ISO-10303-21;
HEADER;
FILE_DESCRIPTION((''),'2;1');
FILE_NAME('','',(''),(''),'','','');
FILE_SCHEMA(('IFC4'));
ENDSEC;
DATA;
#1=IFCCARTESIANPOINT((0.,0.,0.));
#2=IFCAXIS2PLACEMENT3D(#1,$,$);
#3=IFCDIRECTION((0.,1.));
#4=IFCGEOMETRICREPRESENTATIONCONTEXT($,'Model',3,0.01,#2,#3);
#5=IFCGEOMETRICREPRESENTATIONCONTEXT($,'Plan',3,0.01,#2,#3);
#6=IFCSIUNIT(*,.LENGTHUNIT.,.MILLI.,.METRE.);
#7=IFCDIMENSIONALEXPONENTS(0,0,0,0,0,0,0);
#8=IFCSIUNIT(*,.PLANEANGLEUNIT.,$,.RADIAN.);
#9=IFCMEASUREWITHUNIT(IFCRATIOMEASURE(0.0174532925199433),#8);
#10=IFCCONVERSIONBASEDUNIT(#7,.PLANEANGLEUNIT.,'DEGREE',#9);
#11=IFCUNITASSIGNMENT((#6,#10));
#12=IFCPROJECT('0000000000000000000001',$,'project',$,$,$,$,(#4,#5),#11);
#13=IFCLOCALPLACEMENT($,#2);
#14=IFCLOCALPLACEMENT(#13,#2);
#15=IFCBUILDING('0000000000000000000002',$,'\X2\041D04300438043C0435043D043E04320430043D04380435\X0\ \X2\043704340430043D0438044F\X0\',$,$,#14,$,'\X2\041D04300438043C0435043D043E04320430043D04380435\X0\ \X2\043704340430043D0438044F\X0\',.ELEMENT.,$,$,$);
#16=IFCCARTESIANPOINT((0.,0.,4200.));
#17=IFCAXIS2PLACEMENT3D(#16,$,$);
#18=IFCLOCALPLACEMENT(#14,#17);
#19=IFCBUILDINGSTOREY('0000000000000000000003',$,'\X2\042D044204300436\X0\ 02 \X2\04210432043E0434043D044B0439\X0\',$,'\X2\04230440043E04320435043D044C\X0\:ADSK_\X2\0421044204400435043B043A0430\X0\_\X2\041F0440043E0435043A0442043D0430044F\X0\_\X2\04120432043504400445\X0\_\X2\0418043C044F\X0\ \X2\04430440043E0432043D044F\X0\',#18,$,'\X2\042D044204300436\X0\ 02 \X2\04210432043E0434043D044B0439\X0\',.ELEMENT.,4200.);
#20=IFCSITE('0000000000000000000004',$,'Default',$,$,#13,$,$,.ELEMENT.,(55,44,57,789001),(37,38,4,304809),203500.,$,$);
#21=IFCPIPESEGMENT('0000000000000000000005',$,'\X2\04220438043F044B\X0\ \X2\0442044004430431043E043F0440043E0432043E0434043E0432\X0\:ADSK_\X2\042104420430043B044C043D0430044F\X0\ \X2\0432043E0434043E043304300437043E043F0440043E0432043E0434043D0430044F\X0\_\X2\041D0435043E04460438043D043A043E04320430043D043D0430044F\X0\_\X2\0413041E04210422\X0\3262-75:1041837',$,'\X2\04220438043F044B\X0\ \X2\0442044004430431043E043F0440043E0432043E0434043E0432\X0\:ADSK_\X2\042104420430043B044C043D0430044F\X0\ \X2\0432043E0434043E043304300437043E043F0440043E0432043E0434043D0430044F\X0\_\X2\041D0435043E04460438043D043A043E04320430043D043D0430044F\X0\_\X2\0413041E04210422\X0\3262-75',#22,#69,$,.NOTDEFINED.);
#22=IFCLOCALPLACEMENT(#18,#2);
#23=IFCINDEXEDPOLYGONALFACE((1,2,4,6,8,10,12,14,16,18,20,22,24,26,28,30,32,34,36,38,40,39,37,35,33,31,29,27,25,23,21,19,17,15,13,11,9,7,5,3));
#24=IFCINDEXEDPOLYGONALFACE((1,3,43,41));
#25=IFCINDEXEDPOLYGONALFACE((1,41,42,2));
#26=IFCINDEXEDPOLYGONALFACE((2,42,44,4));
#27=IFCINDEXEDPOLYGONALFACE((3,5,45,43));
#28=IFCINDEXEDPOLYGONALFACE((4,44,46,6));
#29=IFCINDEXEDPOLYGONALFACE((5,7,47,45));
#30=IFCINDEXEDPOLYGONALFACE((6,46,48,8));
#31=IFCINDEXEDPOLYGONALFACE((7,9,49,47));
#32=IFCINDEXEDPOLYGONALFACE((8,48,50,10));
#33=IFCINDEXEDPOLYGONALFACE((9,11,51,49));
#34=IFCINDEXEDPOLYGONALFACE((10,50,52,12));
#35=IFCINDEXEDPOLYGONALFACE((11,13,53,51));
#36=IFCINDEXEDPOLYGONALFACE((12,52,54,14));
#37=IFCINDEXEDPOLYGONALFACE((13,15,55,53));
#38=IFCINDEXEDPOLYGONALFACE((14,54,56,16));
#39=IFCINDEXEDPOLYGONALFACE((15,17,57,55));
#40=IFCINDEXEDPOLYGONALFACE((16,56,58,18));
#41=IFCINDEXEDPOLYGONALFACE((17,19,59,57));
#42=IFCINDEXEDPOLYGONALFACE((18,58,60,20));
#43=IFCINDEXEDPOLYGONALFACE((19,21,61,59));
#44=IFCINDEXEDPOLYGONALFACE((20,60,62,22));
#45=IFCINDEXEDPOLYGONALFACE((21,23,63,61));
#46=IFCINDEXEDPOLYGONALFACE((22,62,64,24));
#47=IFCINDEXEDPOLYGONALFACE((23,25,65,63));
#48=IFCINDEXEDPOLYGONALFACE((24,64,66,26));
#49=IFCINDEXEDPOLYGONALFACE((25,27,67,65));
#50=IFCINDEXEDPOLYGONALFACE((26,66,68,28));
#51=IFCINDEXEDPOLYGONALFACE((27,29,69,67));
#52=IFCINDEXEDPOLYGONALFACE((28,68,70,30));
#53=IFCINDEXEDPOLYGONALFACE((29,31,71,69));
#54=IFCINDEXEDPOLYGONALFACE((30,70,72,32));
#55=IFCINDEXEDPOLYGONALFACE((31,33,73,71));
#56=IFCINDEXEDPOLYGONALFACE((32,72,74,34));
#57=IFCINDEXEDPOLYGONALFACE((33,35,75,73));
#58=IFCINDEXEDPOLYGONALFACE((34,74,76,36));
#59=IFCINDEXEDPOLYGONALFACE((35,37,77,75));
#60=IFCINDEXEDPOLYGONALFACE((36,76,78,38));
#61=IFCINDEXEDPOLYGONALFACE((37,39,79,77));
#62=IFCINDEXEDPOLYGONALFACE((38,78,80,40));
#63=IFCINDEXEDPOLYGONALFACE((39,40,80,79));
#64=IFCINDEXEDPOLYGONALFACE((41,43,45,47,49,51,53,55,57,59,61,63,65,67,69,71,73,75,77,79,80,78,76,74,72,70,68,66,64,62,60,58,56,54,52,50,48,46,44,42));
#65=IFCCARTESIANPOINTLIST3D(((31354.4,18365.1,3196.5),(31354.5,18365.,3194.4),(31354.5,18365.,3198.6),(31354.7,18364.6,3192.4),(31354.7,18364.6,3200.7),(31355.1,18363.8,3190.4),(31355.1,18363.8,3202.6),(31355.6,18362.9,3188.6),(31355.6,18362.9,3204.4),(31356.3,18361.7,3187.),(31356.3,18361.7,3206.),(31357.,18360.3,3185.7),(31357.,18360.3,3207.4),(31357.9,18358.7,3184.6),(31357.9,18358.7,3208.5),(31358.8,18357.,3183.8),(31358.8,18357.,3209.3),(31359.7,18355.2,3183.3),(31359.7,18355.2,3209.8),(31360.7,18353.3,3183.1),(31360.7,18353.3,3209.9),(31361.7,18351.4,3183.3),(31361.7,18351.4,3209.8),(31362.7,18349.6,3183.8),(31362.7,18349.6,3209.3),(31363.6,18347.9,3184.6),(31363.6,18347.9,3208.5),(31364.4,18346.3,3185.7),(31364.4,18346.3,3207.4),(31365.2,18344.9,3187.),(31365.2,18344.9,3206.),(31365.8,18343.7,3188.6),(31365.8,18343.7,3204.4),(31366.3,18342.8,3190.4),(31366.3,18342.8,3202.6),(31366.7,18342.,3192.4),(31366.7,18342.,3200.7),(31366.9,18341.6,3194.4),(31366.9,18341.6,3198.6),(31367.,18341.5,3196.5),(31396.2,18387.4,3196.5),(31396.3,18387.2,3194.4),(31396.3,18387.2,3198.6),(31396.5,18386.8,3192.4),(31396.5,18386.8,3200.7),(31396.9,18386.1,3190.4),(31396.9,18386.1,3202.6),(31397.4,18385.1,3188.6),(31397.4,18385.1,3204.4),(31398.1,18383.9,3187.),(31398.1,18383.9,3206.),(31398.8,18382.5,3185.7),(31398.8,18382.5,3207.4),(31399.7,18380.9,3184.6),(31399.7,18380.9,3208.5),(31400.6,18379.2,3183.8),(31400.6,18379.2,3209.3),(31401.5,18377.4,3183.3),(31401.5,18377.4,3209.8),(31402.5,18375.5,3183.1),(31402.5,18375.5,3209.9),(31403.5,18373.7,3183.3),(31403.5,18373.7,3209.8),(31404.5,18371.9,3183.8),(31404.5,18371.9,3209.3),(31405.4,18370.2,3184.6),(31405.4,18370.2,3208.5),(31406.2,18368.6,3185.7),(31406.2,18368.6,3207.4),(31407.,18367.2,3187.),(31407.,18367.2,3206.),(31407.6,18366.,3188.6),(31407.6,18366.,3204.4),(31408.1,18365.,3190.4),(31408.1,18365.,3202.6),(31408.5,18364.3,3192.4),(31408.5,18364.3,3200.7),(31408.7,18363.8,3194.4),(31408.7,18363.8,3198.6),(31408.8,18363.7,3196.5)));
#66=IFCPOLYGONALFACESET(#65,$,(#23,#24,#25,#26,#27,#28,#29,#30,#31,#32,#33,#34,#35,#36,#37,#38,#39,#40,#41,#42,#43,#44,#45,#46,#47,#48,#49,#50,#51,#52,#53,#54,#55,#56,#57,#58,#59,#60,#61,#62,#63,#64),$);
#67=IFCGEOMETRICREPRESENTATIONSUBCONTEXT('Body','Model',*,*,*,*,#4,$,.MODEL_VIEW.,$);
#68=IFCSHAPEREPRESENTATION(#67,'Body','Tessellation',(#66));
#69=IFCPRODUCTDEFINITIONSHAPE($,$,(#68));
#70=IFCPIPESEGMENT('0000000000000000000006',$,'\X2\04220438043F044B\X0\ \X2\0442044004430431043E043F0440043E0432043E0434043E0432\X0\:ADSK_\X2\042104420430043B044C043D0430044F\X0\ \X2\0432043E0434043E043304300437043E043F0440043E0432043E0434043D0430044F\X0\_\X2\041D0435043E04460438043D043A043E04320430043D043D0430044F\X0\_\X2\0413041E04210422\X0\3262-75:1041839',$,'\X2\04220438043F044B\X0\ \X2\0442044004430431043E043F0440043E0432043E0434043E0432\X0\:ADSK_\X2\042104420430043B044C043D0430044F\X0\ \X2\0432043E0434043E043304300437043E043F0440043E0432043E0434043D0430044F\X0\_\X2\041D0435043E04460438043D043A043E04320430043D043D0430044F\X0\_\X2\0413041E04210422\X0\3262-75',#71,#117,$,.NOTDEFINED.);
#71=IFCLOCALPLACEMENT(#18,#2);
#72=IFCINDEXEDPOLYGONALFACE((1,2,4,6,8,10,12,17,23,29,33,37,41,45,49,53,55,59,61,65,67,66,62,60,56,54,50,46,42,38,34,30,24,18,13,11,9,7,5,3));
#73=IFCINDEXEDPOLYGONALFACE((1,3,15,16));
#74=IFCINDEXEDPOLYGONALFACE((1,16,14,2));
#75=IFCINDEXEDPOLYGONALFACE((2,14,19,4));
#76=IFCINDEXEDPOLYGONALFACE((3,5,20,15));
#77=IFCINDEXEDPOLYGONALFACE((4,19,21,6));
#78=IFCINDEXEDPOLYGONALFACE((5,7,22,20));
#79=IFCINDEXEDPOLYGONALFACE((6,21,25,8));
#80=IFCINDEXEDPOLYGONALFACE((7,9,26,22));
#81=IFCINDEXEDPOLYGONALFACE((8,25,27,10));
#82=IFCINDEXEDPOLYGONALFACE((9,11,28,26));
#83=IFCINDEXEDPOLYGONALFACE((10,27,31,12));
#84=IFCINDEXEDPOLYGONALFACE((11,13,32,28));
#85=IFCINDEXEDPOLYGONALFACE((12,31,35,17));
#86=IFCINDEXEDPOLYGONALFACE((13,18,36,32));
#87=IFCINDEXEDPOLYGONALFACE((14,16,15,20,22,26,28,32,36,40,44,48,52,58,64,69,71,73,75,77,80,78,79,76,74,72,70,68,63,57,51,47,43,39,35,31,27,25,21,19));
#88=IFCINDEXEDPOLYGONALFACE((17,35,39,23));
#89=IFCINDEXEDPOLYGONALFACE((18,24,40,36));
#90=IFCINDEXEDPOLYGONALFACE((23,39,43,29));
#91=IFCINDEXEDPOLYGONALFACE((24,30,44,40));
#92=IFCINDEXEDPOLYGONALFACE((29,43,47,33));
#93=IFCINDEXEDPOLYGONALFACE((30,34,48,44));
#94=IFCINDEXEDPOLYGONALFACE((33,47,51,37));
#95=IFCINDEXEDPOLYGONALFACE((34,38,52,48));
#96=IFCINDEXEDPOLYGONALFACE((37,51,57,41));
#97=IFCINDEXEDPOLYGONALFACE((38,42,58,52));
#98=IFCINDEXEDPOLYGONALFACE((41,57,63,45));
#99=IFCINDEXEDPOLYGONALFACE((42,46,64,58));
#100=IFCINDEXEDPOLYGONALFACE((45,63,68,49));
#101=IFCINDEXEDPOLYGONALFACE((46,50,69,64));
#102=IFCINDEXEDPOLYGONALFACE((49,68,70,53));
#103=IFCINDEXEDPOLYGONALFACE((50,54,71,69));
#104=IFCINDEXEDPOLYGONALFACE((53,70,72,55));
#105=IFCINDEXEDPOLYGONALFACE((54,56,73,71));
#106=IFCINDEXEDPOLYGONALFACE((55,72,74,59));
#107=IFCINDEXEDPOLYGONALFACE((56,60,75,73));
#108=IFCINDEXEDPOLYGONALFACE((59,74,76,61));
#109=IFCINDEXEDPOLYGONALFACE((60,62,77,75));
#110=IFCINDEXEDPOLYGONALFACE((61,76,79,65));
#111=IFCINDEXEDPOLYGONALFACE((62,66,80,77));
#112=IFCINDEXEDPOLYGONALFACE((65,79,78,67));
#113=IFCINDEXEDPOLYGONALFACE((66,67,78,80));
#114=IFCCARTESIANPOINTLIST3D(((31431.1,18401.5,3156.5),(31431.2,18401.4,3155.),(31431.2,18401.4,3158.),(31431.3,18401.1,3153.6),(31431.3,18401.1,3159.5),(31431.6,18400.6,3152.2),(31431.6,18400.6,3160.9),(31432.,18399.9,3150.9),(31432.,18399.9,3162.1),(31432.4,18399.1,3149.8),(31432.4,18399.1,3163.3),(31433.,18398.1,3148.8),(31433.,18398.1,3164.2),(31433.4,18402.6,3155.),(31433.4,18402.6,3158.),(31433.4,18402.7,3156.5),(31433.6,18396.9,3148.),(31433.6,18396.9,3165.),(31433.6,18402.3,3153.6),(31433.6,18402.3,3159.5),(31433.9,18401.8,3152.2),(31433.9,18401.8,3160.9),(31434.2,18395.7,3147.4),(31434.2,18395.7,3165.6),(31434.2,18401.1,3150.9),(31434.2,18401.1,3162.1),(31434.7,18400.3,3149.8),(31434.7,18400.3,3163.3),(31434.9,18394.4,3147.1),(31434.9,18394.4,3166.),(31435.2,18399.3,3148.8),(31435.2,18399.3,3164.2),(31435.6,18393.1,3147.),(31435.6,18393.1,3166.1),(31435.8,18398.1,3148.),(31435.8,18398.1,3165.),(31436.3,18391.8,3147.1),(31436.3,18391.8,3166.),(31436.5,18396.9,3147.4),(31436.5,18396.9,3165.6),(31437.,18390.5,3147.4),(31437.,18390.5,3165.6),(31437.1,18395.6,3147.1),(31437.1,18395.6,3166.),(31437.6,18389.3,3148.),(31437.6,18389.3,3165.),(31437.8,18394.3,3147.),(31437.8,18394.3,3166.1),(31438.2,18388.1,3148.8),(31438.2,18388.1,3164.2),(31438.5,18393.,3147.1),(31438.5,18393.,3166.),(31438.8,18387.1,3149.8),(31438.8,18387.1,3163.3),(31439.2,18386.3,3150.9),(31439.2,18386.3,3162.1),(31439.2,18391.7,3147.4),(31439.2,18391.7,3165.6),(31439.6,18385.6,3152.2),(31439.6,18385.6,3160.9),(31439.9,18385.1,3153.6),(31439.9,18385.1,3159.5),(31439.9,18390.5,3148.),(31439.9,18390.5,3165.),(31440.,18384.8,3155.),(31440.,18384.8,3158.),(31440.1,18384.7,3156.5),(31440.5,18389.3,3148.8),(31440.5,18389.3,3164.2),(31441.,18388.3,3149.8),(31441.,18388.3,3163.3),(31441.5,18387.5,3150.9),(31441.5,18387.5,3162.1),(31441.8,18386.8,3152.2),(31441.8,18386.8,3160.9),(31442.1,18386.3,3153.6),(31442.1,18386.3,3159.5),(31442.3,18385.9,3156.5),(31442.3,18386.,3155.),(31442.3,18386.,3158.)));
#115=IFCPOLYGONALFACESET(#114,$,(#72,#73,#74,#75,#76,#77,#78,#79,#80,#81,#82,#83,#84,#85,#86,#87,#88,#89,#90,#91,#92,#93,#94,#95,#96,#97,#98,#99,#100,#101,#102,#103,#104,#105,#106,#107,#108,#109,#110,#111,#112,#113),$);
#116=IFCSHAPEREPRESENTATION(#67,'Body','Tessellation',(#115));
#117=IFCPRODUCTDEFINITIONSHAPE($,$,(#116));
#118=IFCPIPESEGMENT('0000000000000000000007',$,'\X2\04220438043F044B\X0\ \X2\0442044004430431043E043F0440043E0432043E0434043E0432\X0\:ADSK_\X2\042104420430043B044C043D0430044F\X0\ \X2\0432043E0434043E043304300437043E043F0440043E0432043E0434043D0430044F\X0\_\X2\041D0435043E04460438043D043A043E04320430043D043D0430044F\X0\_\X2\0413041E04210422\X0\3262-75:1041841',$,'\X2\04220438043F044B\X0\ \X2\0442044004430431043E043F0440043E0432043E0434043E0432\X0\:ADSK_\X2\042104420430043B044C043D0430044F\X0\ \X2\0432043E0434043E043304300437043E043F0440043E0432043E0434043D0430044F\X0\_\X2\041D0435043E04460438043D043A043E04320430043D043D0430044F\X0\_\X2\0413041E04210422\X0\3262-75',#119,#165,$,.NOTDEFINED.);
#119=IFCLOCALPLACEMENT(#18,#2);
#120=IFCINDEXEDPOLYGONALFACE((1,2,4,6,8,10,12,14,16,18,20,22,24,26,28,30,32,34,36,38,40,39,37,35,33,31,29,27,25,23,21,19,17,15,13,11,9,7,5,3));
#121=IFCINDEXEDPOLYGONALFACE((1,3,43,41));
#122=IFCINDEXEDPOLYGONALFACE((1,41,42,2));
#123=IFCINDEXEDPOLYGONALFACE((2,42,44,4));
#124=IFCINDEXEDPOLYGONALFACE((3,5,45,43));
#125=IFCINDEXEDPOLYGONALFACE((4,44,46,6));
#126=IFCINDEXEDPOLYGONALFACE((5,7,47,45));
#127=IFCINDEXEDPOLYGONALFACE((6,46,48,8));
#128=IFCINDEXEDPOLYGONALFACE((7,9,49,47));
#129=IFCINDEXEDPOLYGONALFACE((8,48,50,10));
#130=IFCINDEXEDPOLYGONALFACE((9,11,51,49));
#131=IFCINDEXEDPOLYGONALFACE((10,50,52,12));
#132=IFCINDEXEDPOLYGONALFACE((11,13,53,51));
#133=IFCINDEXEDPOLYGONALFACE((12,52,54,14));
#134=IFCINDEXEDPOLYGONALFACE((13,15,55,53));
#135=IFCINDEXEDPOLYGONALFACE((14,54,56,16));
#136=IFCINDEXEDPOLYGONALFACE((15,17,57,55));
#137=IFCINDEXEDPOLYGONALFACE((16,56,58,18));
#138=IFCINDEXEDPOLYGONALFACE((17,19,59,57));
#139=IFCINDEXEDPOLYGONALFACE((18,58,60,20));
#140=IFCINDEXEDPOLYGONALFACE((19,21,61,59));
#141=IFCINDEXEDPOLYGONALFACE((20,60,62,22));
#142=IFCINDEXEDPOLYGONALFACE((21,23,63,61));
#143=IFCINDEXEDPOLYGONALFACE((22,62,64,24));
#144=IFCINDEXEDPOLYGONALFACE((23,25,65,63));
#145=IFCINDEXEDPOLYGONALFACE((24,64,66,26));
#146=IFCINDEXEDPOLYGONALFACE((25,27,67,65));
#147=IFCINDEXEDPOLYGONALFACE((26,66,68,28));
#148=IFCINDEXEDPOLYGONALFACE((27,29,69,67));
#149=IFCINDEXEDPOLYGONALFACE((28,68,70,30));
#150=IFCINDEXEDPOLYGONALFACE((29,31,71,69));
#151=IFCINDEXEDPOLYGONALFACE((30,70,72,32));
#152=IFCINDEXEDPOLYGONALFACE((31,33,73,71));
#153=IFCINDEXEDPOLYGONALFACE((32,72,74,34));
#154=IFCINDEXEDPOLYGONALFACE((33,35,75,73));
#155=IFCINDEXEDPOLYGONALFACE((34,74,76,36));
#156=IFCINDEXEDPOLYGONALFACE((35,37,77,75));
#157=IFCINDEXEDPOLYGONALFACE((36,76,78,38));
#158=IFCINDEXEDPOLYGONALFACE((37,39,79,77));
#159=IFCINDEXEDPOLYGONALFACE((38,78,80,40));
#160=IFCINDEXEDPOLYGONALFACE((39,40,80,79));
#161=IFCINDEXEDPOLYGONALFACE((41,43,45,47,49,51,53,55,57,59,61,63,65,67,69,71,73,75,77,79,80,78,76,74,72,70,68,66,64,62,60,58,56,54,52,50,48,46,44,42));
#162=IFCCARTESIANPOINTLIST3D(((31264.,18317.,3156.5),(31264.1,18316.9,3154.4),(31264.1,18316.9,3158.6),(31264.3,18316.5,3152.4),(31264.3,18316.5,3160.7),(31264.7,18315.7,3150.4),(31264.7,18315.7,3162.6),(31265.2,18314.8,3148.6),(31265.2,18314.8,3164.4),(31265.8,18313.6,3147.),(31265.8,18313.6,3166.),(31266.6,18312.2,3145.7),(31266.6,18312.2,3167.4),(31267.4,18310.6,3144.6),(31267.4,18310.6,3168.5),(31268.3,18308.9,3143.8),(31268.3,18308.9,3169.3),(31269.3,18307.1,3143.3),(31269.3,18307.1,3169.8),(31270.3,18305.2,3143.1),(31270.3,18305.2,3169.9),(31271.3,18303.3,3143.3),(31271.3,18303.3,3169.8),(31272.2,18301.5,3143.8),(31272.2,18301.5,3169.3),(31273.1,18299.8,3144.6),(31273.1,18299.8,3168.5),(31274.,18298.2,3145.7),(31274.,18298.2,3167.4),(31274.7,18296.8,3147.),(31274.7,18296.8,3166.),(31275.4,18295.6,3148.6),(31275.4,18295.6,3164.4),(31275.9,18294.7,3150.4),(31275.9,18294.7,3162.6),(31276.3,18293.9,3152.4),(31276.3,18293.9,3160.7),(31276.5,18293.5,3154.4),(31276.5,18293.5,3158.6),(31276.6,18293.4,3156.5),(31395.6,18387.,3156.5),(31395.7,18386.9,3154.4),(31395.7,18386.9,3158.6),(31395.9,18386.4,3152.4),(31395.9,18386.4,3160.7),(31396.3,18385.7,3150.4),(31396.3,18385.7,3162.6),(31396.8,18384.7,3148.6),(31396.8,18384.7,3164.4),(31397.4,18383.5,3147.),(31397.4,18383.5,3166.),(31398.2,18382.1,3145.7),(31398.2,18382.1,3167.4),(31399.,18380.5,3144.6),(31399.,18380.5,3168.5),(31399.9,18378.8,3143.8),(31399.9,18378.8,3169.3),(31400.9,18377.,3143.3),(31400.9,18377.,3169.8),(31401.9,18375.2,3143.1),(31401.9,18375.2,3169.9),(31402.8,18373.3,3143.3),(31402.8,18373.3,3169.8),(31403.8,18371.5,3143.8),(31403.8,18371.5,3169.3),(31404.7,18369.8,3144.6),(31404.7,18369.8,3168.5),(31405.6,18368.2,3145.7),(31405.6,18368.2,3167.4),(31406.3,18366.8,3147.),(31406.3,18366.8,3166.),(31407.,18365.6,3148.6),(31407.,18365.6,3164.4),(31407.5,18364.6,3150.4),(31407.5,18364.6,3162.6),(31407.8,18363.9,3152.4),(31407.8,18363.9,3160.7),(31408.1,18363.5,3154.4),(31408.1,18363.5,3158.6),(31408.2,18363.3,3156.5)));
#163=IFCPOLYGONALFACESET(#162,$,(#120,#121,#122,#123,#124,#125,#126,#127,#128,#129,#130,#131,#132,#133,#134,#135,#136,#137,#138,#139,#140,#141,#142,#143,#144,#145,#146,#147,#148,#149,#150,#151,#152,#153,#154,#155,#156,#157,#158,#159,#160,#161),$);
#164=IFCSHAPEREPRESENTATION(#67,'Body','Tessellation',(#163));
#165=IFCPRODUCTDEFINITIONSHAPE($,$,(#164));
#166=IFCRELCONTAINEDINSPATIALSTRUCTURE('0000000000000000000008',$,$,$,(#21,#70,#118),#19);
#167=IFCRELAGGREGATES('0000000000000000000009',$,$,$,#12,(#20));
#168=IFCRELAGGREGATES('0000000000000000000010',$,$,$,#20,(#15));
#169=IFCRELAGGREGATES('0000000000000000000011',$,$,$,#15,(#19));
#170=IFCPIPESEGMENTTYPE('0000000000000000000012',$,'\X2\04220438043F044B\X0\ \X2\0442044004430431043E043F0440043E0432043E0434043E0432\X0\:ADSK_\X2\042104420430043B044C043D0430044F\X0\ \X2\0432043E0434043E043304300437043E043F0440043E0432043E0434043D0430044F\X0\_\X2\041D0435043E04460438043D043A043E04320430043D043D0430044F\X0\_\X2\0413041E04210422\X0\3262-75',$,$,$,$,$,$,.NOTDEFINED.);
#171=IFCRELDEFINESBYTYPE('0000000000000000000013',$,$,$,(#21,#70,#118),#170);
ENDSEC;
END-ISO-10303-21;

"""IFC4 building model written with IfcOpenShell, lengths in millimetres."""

from ifc_helpers import new_model, entity, si_unit, converted_unit, direction, frame, origin, place, context, subcontext, project, spatial, indexed_curve, outline, extrude, type_object, element, save


model = new_model("IFC4")

# Units and contexts
model_context = context("Model", 3, precision=0.01, world=origin(), true_north=direction((0.0, 1.0)))
plan_context = context("Plan", 3, precision=0.01, world=origin(), true_north=direction((0.0, 1.0)))
body_context = subcontext(model_context, "Body", "Model", "MODEL_VIEW")
ifc_project = project(units=[si_unit("LENGTHUNIT", "METRE", prefix="MILLI"), converted_unit("PLANEANGLEUNIT", "DEGREE", entity("IfcRatioMeasure", 0.0174532925199433), si_unit("PLANEANGLEUNIT", "RADIAN"), dimensions=[0, 0, 0, 0, 0, 0, 0])], contexts=[model_context, plan_context])

# Site, building, storey
site_placement = place(None, origin())
site = spatial("IfcSite", under=ifc_project, at=site_placement, Name="Default", CompositionType="ELEMENT", RefLatitude=(55, 44, 57, 789001), RefLongitude=(37, 38, 4, 304809), RefElevation=203500.0)
building_placement = place(site_placement, origin())
building = spatial("IfcBuilding", under=site, at=building_placement, Name="Наименование здания", LongName="Наименование здания", CompositionType="ELEMENT")
storey_placement = place(building_placement, frame((0.0, 0.0, 4200.0)))
storey = spatial("IfcBuildingStorey", under=building, at=storey_placement, Name="Этаж 02 Сводный", ObjectType="Уровень:ADSK_Стрелка_Проектная_Вверх_Имя уровня", LongName="Этаж 02 Сводный", CompositionType="ELEMENT", Elevation=4200.0)

# Pipe segments
pipe_segment_type = type_object("IfcPipeSegmentType", Name="Типы трубопроводов:ADSK_Стальная водогазопроводная_Неоцинкованная_ГОСТ3262-75", PredefinedType="NOTDEFINED")
placement = place(storey_placement, origin())
element("IfcPipeSegment", 1, at=placement, inside=storey, type_object=pipe_segment_type, Name="Типы трубопроводов:ADSK_Стальная водогазопроводная_Неоцинкованная_ГОСТ3262-75:1041837", ObjectType="Типы трубопроводов:ADSK_Стальная водогазопроводная_Неоцинкованная_ГОСТ3262-75", PredefinedType="NOTDEFINED", context=body_context, shape_type="SweptSolid", body=[
    extrude(outline(indexed_curve([(13.4, 0.0), (13.2, 2.1), (12.7, 4.1), (11.9, 6.1), (10.8, 7.9), (9.5, 9.5), (7.9, 10.8), (6.1, 11.9), (4.1, 12.7), (2.1, 13.2), (0.0, 13.4), (-2.1, 13.2), (-4.1, 12.7), (-6.1, 11.9), (-7.9, 10.8), (-9.5, 9.5), (-10.8, 7.9), (-11.9, 6.1), (-12.7, 4.1), (-13.2, 2.1), (-13.4, 0.0), (-13.2, -2.1), (-12.7, -4.1), (-11.9, -6.1), (-10.8, -7.9), (-9.5, -9.5), (-7.9, -10.8), (-6.1, -11.9), (-4.1, -12.7), (-2.1, -13.2), (0.0, -13.4), (2.1, -13.2), (4.1, -12.7), (6.1, -11.9), (7.9, -10.8), (9.5, -9.5), (10.8, -7.9), (11.9, -6.1), (12.7, -4.1), (13.2, -2.1), (13.4, 0.0)], self_intersect=False)), frame((31360.7, 18353.3, 3196.5), z_axis=(0.882948, 0.469472, 0.0), x_axis=(-0.469472, 0.882948, 0.0)), (0.0, 0.0, 1.0), 47.3),
])
element("IfcPipeSegment", 2, at=placement, inside=storey, type_object=pipe_segment_type, Name="Типы трубопроводов:ADSK_Стальная водогазопроводная_Неоцинкованная_ГОСТ3262-75:1041839", ObjectType="Типы трубопроводов:ADSK_Стальная водогазопроводная_Неоцинкованная_ГОСТ3262-75", PredefinedType="NOTDEFINED", context=body_context, shape_type="SweptSolid", body=[
    extrude(outline(indexed_curve([(9.6, 0.0), (9.4, 1.5), (9.1, 3.0), (8.5, 4.3), (7.7, 5.6), (6.8, 6.8), (5.6, 7.7), (4.3, 8.5), (3.0, 9.1), (1.5, 9.4), (0.0, 9.6), (-1.5, 9.4), (-3.0, 9.1), (-4.3, 8.5), (-5.6, 7.7), (-6.8, 6.8), (-7.7, 5.6), (-8.5, 4.3), (-9.1, 3.0), (-9.4, 1.5), (-9.6, 0.0), (-9.4, -1.5), (-9.1, -3.0), (-8.5, -4.3), (-7.7, -5.6), (-6.8, -6.8), (-5.6, -7.7), (-4.3, -8.5), (-3.0, -9.1), (-1.5, -9.4), (0.0, -9.6), (1.5, -9.4), (3.0, -9.1), (4.3, -8.5), (5.6, -7.7), (6.8, -6.8), (7.7, -5.6), (8.5, -4.3), (9.1, -3.0), (9.4, -1.5), (9.6, 0.0)], self_intersect=False)), frame((31435.6, 18393.1, 3156.5), z_axis=(0.882948, 0.469472, 0.0), x_axis=(-0.469472, 0.882948, 0.0)), (0.0, 0.0, 1.0), 2.6),
])
element("IfcPipeSegment", 3, at=placement, inside=storey, type_object=pipe_segment_type, Name="Типы трубопроводов:ADSK_Стальная водогазопроводная_Неоцинкованная_ГОСТ3262-75:1041841", ObjectType="Типы трубопроводов:ADSK_Стальная водогазопроводная_Неоцинкованная_ГОСТ3262-75", PredefinedType="NOTDEFINED", context=body_context, shape_type="SweptSolid", body=[
    extrude(outline(indexed_curve([(13.4, 0.0), (13.2, 2.1), (12.7, 4.1), (11.9, 6.1), (10.8, 7.9), (9.5, 9.5), (7.9, 10.8), (6.1, 11.9), (4.1, 12.7), (2.1, 13.2), (0.0, 13.4), (-2.1, 13.2), (-4.1, 12.7), (-6.1, 11.9), (-7.9, 10.8), (-9.5, 9.5), (-10.8, 7.9), (-11.9, 6.1), (-12.7, 4.1), (-13.2, 2.1), (-13.4, 0.0), (-13.2, -2.1), (-12.7, -4.1), (-11.9, -6.1), (-10.8, -7.9), (-9.5, -9.5), (-7.9, -10.8), (-6.1, -11.9), (-4.1, -12.7), (-2.1, -13.2), (0.0, -13.4), (2.1, -13.2), (4.1, -12.7), (6.1, -11.9), (7.9, -10.8), (9.5, -9.5), (10.8, -7.9), (11.9, -6.1), (12.7, -4.1), (13.2, -2.1), (13.4, 0.0)], self_intersect=False)), frame((31270.3, 18305.2, 3156.5), z_axis=(0.882948, 0.469472, 0.0), x_axis=(0.469472, -0.882948, 0.0)), (0.0, 0.0, 1.0), 149.0),
])

save(model, "model.ifc")
